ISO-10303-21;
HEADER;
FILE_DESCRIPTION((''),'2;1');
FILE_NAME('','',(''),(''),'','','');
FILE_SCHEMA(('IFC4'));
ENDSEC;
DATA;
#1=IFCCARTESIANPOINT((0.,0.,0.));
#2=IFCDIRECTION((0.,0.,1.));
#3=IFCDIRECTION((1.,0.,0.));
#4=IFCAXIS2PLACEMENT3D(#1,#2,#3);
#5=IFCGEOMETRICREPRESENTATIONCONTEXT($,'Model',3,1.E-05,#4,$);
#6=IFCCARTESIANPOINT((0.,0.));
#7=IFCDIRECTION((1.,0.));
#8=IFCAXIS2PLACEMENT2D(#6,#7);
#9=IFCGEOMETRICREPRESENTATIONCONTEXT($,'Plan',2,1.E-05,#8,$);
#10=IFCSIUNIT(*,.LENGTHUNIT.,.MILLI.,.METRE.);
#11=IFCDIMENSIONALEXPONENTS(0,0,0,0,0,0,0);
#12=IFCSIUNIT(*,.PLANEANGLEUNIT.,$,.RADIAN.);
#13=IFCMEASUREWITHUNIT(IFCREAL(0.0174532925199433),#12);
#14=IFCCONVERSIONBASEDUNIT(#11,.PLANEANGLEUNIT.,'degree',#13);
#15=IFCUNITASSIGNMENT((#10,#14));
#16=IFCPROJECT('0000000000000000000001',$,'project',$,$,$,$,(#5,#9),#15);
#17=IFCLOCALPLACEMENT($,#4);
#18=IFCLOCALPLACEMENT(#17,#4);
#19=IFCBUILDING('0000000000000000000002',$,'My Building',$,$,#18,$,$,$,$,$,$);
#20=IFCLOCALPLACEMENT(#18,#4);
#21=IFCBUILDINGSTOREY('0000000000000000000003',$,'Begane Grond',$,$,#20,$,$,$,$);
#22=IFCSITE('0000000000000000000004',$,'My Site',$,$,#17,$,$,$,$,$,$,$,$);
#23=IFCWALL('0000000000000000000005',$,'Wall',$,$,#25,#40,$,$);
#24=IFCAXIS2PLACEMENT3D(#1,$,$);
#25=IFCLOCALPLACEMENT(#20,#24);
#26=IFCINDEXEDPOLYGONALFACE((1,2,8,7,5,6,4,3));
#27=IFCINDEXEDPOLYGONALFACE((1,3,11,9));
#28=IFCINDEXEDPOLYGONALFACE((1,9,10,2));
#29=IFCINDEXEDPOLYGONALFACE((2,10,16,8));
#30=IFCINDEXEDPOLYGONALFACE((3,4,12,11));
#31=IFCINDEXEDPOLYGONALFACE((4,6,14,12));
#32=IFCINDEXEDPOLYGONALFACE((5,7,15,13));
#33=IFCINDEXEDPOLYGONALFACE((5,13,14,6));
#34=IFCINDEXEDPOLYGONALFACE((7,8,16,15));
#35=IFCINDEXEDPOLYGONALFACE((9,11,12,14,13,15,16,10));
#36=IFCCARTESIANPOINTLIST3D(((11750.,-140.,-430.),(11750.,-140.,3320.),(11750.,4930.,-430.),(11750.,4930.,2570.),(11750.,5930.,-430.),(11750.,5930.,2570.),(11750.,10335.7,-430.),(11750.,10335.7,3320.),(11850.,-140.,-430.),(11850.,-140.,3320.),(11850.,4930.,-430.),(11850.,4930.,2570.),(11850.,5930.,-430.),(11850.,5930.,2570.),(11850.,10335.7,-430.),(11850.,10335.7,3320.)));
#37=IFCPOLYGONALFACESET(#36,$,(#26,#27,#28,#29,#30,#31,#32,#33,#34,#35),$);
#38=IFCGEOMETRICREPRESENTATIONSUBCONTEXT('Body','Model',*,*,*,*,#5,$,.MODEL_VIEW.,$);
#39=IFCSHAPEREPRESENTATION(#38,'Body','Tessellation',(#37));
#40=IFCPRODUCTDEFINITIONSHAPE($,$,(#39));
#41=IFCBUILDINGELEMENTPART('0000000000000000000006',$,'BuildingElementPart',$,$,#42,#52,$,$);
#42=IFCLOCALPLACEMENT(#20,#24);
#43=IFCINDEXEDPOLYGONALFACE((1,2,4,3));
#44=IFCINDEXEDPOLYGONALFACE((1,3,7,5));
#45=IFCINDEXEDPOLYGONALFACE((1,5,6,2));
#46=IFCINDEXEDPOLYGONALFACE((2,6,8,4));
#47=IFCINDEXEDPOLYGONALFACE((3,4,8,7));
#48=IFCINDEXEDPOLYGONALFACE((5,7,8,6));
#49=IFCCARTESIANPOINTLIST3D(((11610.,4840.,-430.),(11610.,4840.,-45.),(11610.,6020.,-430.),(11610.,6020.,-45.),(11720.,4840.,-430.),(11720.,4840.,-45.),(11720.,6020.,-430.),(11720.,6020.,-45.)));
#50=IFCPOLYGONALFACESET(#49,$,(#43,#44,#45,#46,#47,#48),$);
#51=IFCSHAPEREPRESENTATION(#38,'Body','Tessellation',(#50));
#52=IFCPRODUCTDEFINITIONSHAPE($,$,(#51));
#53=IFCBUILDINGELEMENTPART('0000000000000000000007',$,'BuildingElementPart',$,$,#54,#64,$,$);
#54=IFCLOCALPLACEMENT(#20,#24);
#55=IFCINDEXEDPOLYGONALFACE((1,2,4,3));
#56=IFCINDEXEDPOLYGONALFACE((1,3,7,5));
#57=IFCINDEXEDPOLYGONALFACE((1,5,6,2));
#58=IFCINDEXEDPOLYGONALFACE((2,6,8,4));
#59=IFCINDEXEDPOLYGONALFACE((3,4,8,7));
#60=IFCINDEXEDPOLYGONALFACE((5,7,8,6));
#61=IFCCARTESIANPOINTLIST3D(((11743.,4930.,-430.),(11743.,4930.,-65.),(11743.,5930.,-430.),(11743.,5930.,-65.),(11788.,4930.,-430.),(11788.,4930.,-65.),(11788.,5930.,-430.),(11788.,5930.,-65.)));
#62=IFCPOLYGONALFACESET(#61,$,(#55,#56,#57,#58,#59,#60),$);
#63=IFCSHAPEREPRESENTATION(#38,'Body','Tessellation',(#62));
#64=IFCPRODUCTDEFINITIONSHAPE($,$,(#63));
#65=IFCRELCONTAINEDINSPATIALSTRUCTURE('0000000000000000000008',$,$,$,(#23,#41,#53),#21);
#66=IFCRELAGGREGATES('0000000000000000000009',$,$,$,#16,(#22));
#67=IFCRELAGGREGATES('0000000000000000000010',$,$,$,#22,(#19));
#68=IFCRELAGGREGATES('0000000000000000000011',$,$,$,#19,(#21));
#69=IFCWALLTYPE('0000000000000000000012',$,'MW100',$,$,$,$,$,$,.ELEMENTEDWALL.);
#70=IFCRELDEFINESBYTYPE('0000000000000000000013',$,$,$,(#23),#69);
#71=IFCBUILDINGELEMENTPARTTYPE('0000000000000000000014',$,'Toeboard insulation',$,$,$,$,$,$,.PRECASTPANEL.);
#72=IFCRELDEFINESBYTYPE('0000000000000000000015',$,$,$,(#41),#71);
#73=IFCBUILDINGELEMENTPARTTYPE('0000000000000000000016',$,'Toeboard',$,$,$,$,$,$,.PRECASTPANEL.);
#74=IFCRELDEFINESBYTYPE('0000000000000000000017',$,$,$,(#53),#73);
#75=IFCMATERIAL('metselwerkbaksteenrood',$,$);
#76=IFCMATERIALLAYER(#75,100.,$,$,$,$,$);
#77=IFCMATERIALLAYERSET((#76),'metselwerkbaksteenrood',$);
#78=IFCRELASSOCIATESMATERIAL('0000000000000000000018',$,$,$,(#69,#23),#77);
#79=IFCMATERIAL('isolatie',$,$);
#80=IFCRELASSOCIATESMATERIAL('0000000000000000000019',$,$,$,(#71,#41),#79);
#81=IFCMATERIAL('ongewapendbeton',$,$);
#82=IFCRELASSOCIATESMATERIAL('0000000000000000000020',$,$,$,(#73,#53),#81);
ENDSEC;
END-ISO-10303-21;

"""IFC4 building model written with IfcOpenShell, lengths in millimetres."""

from ifc_helpers import new_model, entity, si_unit, converted_unit, frame, origin_with_axes, origin_2d_with_axis, place, context, subcontext, project, spatial, line, indexed_curve, rectangle, outline, extrude, source, transform, mapped, material, layer, layer_set, layer_usage, material_profile, profile_set, profile_usage, type_object, element, save


model = new_model("IFC4")

# Units and contexts
model_context = context("Model", 3, precision=1e-05, world=origin_with_axes())
plan_context = context("Plan", 2, precision=1e-05, world=origin_2d_with_axis())
body_context = subcontext(model_context, "Body", "Model", "MODEL_VIEW")
ifc_project = project(units=[si_unit("LENGTHUNIT", "METRE", prefix="MILLI"), converted_unit("PLANEANGLEUNIT", "degree", entity("IfcReal", 0.0174532925199433), si_unit("PLANEANGLEUNIT", "RADIAN"), dimensions=[0, 0, 0, 0, 0, 0, 0])], contexts=[model_context, plan_context])

# Site, building, storey
site_placement = place(None, origin_with_axes())
site = spatial("IfcSite", under=ifc_project, at=site_placement, Name="My Site")
building_placement = place(site_placement, origin_with_axes())
building = spatial("IfcBuilding", under=site, at=building_placement, Name="My Building")
storey_placement = place(building_placement, origin_with_axes())
storey = spatial("IfcBuildingStorey", under=building, at=storey_placement, Name="Begane Grond")

# Shared definitions
ifc_material_1 = material(Name="ongewapendbeton")

# Wall, opening
ifc_material_2 = material(Name="metselwerkbaksteenrood")
ifc_layer_1 = layer(ifc_material_2, 100.0)
ifc_layer_set_1 = layer_set([ifc_layer_1], Name="metselwerkbaksteenrood")
ifc_layer_usage_1 = layer_usage(ifc_layer_set_1, "AXIS2", "POSITIVE", 0.0)
wall_type_1 = type_object("IfcWallType", Name="MW100", PredefinedType="ELEMENTEDWALL", material=ifc_layer_set_1)
wall_1_placement = place(storey_placement, frame((11850.0, -140.0, -430.0), z_axis=(0.0, 0.0, 1.0), x_axis=(0.0, 1.0, 0.0)))
wall_1 = element("IfcWall", 1, at=wall_1_placement, inside=storey, type_object=wall_type_1, material=ifc_layer_usage_1, Name="Wall", context=body_context, shape_type="SweptSolid", body=[
    extrude(outline(indexed_curve([(0.0, 0.0), (0.0, 100.0), (10475.7, 100.0), (10475.7, 0.0), (0.0, 0.0)], self_intersect=False)), origin_with_axes(), (0.0, 0.0, 1.0), 3750.0),
])
shared_shape_1 = source(origin_with_axes(), body_context, "Body", "SweptSolid", [
    extrude(outline(indexed_curve([(0.0, -434.9), (0.0, 2570.1), (1000.0, 2570.1), (1000.0, -434.9)], segments=[line(3, 2), line(2, 1), line(1, 4), line(4, 3)], self_intersect=False)), frame((0.0, -600.0, -0.1), z_axis=(0.0, -1.0, 0.0), x_axis=(1.0, 0.0, 0.0)), (0.0, 0.0, -1.0), 1200.0),
])
opening_1_placement = place(wall_1_placement, frame((5070.0, 210.0, 430.0), z_axis=(0.0, 0.0, 1.0), x_axis=(1.0, 0.0, 0.0)))
element("IfcOpeningElement", 2, at=opening_1_placement, cuts=wall_1, PredefinedType="OPENING", context=body_context, shape_type="MappedRepresentation", body=[
    mapped(shared_shape_1, transform((0.0, 0.0, 0.0), x_axis=(1.0, 0.0, 0.0), y_axis=(0.0, 1.0, 0.0), z_axis=(0.0, 0.0, 1.0), scale=1.0)),
])

# Building element parts
ifc_material_3 = material(Name="isolatie")
ifc_material_profile_1 = material_profile(ifc_material_3, rectangle(XDim=110.0, YDim=385.0))
ifc_profile_set_1 = profile_set([ifc_material_profile_1], Name="isolatieEPS")
ifc_profile_usage_1 = profile_usage(ifc_profile_set_1)
building_element_part_type_1 = type_object("IfcBuildingElementPartType", Name="Toeboard insulation", PredefinedType="PRECASTPANEL", material=ifc_profile_set_1)
building_element_part_1_placement = place(storey_placement, frame((11665.0, 4840.0, -237.5), z_axis=(0.0, 1.0, 0.0), x_axis=(-1.0, 0.0, 0.0)))
element("IfcBuildingElementPart", 3, at=building_element_part_1_placement, inside=storey, type_object=building_element_part_type_1, material=ifc_profile_usage_1, Name="BuildingElementPart", context=body_context, shape_type="SweptSolid", body=[
    extrude(rectangle(XDim=110.0, YDim=385.0), origin_with_axes(), (0.0, 0.0, 1.0), 1180.0),
])
ifc_material_profile_2 = material_profile(ifc_material_1, rectangle(XDim=45.0, YDim=365.0))
ifc_profile_set_2 = profile_set([ifc_material_profile_2], Name="ongewapendbeton")
ifc_profile_usage_2 = profile_usage(ifc_profile_set_2)
building_element_part_type_2 = type_object("IfcBuildingElementPartType", Name="Toeboard", PredefinedType="PRECASTPANEL", material=ifc_profile_set_2)
building_element_part_2_placement = place(storey_placement, frame((11765.5, 4930.0, -247.5), z_axis=(0.0, 1.0, 0.0), x_axis=(-1.0, 0.0, 0.0)))
element("IfcBuildingElementPart", 4, at=building_element_part_2_placement, inside=storey, type_object=building_element_part_type_2, material=ifc_profile_usage_2, Name="BuildingElementPart", context=body_context, shape_type="SweptSolid", body=[
    extrude(rectangle(XDim=45.0, YDim=365.0), origin_with_axes(), (0.0, 0.0, 1.0), 1000.0),
])

save(model, "model.ifc")
